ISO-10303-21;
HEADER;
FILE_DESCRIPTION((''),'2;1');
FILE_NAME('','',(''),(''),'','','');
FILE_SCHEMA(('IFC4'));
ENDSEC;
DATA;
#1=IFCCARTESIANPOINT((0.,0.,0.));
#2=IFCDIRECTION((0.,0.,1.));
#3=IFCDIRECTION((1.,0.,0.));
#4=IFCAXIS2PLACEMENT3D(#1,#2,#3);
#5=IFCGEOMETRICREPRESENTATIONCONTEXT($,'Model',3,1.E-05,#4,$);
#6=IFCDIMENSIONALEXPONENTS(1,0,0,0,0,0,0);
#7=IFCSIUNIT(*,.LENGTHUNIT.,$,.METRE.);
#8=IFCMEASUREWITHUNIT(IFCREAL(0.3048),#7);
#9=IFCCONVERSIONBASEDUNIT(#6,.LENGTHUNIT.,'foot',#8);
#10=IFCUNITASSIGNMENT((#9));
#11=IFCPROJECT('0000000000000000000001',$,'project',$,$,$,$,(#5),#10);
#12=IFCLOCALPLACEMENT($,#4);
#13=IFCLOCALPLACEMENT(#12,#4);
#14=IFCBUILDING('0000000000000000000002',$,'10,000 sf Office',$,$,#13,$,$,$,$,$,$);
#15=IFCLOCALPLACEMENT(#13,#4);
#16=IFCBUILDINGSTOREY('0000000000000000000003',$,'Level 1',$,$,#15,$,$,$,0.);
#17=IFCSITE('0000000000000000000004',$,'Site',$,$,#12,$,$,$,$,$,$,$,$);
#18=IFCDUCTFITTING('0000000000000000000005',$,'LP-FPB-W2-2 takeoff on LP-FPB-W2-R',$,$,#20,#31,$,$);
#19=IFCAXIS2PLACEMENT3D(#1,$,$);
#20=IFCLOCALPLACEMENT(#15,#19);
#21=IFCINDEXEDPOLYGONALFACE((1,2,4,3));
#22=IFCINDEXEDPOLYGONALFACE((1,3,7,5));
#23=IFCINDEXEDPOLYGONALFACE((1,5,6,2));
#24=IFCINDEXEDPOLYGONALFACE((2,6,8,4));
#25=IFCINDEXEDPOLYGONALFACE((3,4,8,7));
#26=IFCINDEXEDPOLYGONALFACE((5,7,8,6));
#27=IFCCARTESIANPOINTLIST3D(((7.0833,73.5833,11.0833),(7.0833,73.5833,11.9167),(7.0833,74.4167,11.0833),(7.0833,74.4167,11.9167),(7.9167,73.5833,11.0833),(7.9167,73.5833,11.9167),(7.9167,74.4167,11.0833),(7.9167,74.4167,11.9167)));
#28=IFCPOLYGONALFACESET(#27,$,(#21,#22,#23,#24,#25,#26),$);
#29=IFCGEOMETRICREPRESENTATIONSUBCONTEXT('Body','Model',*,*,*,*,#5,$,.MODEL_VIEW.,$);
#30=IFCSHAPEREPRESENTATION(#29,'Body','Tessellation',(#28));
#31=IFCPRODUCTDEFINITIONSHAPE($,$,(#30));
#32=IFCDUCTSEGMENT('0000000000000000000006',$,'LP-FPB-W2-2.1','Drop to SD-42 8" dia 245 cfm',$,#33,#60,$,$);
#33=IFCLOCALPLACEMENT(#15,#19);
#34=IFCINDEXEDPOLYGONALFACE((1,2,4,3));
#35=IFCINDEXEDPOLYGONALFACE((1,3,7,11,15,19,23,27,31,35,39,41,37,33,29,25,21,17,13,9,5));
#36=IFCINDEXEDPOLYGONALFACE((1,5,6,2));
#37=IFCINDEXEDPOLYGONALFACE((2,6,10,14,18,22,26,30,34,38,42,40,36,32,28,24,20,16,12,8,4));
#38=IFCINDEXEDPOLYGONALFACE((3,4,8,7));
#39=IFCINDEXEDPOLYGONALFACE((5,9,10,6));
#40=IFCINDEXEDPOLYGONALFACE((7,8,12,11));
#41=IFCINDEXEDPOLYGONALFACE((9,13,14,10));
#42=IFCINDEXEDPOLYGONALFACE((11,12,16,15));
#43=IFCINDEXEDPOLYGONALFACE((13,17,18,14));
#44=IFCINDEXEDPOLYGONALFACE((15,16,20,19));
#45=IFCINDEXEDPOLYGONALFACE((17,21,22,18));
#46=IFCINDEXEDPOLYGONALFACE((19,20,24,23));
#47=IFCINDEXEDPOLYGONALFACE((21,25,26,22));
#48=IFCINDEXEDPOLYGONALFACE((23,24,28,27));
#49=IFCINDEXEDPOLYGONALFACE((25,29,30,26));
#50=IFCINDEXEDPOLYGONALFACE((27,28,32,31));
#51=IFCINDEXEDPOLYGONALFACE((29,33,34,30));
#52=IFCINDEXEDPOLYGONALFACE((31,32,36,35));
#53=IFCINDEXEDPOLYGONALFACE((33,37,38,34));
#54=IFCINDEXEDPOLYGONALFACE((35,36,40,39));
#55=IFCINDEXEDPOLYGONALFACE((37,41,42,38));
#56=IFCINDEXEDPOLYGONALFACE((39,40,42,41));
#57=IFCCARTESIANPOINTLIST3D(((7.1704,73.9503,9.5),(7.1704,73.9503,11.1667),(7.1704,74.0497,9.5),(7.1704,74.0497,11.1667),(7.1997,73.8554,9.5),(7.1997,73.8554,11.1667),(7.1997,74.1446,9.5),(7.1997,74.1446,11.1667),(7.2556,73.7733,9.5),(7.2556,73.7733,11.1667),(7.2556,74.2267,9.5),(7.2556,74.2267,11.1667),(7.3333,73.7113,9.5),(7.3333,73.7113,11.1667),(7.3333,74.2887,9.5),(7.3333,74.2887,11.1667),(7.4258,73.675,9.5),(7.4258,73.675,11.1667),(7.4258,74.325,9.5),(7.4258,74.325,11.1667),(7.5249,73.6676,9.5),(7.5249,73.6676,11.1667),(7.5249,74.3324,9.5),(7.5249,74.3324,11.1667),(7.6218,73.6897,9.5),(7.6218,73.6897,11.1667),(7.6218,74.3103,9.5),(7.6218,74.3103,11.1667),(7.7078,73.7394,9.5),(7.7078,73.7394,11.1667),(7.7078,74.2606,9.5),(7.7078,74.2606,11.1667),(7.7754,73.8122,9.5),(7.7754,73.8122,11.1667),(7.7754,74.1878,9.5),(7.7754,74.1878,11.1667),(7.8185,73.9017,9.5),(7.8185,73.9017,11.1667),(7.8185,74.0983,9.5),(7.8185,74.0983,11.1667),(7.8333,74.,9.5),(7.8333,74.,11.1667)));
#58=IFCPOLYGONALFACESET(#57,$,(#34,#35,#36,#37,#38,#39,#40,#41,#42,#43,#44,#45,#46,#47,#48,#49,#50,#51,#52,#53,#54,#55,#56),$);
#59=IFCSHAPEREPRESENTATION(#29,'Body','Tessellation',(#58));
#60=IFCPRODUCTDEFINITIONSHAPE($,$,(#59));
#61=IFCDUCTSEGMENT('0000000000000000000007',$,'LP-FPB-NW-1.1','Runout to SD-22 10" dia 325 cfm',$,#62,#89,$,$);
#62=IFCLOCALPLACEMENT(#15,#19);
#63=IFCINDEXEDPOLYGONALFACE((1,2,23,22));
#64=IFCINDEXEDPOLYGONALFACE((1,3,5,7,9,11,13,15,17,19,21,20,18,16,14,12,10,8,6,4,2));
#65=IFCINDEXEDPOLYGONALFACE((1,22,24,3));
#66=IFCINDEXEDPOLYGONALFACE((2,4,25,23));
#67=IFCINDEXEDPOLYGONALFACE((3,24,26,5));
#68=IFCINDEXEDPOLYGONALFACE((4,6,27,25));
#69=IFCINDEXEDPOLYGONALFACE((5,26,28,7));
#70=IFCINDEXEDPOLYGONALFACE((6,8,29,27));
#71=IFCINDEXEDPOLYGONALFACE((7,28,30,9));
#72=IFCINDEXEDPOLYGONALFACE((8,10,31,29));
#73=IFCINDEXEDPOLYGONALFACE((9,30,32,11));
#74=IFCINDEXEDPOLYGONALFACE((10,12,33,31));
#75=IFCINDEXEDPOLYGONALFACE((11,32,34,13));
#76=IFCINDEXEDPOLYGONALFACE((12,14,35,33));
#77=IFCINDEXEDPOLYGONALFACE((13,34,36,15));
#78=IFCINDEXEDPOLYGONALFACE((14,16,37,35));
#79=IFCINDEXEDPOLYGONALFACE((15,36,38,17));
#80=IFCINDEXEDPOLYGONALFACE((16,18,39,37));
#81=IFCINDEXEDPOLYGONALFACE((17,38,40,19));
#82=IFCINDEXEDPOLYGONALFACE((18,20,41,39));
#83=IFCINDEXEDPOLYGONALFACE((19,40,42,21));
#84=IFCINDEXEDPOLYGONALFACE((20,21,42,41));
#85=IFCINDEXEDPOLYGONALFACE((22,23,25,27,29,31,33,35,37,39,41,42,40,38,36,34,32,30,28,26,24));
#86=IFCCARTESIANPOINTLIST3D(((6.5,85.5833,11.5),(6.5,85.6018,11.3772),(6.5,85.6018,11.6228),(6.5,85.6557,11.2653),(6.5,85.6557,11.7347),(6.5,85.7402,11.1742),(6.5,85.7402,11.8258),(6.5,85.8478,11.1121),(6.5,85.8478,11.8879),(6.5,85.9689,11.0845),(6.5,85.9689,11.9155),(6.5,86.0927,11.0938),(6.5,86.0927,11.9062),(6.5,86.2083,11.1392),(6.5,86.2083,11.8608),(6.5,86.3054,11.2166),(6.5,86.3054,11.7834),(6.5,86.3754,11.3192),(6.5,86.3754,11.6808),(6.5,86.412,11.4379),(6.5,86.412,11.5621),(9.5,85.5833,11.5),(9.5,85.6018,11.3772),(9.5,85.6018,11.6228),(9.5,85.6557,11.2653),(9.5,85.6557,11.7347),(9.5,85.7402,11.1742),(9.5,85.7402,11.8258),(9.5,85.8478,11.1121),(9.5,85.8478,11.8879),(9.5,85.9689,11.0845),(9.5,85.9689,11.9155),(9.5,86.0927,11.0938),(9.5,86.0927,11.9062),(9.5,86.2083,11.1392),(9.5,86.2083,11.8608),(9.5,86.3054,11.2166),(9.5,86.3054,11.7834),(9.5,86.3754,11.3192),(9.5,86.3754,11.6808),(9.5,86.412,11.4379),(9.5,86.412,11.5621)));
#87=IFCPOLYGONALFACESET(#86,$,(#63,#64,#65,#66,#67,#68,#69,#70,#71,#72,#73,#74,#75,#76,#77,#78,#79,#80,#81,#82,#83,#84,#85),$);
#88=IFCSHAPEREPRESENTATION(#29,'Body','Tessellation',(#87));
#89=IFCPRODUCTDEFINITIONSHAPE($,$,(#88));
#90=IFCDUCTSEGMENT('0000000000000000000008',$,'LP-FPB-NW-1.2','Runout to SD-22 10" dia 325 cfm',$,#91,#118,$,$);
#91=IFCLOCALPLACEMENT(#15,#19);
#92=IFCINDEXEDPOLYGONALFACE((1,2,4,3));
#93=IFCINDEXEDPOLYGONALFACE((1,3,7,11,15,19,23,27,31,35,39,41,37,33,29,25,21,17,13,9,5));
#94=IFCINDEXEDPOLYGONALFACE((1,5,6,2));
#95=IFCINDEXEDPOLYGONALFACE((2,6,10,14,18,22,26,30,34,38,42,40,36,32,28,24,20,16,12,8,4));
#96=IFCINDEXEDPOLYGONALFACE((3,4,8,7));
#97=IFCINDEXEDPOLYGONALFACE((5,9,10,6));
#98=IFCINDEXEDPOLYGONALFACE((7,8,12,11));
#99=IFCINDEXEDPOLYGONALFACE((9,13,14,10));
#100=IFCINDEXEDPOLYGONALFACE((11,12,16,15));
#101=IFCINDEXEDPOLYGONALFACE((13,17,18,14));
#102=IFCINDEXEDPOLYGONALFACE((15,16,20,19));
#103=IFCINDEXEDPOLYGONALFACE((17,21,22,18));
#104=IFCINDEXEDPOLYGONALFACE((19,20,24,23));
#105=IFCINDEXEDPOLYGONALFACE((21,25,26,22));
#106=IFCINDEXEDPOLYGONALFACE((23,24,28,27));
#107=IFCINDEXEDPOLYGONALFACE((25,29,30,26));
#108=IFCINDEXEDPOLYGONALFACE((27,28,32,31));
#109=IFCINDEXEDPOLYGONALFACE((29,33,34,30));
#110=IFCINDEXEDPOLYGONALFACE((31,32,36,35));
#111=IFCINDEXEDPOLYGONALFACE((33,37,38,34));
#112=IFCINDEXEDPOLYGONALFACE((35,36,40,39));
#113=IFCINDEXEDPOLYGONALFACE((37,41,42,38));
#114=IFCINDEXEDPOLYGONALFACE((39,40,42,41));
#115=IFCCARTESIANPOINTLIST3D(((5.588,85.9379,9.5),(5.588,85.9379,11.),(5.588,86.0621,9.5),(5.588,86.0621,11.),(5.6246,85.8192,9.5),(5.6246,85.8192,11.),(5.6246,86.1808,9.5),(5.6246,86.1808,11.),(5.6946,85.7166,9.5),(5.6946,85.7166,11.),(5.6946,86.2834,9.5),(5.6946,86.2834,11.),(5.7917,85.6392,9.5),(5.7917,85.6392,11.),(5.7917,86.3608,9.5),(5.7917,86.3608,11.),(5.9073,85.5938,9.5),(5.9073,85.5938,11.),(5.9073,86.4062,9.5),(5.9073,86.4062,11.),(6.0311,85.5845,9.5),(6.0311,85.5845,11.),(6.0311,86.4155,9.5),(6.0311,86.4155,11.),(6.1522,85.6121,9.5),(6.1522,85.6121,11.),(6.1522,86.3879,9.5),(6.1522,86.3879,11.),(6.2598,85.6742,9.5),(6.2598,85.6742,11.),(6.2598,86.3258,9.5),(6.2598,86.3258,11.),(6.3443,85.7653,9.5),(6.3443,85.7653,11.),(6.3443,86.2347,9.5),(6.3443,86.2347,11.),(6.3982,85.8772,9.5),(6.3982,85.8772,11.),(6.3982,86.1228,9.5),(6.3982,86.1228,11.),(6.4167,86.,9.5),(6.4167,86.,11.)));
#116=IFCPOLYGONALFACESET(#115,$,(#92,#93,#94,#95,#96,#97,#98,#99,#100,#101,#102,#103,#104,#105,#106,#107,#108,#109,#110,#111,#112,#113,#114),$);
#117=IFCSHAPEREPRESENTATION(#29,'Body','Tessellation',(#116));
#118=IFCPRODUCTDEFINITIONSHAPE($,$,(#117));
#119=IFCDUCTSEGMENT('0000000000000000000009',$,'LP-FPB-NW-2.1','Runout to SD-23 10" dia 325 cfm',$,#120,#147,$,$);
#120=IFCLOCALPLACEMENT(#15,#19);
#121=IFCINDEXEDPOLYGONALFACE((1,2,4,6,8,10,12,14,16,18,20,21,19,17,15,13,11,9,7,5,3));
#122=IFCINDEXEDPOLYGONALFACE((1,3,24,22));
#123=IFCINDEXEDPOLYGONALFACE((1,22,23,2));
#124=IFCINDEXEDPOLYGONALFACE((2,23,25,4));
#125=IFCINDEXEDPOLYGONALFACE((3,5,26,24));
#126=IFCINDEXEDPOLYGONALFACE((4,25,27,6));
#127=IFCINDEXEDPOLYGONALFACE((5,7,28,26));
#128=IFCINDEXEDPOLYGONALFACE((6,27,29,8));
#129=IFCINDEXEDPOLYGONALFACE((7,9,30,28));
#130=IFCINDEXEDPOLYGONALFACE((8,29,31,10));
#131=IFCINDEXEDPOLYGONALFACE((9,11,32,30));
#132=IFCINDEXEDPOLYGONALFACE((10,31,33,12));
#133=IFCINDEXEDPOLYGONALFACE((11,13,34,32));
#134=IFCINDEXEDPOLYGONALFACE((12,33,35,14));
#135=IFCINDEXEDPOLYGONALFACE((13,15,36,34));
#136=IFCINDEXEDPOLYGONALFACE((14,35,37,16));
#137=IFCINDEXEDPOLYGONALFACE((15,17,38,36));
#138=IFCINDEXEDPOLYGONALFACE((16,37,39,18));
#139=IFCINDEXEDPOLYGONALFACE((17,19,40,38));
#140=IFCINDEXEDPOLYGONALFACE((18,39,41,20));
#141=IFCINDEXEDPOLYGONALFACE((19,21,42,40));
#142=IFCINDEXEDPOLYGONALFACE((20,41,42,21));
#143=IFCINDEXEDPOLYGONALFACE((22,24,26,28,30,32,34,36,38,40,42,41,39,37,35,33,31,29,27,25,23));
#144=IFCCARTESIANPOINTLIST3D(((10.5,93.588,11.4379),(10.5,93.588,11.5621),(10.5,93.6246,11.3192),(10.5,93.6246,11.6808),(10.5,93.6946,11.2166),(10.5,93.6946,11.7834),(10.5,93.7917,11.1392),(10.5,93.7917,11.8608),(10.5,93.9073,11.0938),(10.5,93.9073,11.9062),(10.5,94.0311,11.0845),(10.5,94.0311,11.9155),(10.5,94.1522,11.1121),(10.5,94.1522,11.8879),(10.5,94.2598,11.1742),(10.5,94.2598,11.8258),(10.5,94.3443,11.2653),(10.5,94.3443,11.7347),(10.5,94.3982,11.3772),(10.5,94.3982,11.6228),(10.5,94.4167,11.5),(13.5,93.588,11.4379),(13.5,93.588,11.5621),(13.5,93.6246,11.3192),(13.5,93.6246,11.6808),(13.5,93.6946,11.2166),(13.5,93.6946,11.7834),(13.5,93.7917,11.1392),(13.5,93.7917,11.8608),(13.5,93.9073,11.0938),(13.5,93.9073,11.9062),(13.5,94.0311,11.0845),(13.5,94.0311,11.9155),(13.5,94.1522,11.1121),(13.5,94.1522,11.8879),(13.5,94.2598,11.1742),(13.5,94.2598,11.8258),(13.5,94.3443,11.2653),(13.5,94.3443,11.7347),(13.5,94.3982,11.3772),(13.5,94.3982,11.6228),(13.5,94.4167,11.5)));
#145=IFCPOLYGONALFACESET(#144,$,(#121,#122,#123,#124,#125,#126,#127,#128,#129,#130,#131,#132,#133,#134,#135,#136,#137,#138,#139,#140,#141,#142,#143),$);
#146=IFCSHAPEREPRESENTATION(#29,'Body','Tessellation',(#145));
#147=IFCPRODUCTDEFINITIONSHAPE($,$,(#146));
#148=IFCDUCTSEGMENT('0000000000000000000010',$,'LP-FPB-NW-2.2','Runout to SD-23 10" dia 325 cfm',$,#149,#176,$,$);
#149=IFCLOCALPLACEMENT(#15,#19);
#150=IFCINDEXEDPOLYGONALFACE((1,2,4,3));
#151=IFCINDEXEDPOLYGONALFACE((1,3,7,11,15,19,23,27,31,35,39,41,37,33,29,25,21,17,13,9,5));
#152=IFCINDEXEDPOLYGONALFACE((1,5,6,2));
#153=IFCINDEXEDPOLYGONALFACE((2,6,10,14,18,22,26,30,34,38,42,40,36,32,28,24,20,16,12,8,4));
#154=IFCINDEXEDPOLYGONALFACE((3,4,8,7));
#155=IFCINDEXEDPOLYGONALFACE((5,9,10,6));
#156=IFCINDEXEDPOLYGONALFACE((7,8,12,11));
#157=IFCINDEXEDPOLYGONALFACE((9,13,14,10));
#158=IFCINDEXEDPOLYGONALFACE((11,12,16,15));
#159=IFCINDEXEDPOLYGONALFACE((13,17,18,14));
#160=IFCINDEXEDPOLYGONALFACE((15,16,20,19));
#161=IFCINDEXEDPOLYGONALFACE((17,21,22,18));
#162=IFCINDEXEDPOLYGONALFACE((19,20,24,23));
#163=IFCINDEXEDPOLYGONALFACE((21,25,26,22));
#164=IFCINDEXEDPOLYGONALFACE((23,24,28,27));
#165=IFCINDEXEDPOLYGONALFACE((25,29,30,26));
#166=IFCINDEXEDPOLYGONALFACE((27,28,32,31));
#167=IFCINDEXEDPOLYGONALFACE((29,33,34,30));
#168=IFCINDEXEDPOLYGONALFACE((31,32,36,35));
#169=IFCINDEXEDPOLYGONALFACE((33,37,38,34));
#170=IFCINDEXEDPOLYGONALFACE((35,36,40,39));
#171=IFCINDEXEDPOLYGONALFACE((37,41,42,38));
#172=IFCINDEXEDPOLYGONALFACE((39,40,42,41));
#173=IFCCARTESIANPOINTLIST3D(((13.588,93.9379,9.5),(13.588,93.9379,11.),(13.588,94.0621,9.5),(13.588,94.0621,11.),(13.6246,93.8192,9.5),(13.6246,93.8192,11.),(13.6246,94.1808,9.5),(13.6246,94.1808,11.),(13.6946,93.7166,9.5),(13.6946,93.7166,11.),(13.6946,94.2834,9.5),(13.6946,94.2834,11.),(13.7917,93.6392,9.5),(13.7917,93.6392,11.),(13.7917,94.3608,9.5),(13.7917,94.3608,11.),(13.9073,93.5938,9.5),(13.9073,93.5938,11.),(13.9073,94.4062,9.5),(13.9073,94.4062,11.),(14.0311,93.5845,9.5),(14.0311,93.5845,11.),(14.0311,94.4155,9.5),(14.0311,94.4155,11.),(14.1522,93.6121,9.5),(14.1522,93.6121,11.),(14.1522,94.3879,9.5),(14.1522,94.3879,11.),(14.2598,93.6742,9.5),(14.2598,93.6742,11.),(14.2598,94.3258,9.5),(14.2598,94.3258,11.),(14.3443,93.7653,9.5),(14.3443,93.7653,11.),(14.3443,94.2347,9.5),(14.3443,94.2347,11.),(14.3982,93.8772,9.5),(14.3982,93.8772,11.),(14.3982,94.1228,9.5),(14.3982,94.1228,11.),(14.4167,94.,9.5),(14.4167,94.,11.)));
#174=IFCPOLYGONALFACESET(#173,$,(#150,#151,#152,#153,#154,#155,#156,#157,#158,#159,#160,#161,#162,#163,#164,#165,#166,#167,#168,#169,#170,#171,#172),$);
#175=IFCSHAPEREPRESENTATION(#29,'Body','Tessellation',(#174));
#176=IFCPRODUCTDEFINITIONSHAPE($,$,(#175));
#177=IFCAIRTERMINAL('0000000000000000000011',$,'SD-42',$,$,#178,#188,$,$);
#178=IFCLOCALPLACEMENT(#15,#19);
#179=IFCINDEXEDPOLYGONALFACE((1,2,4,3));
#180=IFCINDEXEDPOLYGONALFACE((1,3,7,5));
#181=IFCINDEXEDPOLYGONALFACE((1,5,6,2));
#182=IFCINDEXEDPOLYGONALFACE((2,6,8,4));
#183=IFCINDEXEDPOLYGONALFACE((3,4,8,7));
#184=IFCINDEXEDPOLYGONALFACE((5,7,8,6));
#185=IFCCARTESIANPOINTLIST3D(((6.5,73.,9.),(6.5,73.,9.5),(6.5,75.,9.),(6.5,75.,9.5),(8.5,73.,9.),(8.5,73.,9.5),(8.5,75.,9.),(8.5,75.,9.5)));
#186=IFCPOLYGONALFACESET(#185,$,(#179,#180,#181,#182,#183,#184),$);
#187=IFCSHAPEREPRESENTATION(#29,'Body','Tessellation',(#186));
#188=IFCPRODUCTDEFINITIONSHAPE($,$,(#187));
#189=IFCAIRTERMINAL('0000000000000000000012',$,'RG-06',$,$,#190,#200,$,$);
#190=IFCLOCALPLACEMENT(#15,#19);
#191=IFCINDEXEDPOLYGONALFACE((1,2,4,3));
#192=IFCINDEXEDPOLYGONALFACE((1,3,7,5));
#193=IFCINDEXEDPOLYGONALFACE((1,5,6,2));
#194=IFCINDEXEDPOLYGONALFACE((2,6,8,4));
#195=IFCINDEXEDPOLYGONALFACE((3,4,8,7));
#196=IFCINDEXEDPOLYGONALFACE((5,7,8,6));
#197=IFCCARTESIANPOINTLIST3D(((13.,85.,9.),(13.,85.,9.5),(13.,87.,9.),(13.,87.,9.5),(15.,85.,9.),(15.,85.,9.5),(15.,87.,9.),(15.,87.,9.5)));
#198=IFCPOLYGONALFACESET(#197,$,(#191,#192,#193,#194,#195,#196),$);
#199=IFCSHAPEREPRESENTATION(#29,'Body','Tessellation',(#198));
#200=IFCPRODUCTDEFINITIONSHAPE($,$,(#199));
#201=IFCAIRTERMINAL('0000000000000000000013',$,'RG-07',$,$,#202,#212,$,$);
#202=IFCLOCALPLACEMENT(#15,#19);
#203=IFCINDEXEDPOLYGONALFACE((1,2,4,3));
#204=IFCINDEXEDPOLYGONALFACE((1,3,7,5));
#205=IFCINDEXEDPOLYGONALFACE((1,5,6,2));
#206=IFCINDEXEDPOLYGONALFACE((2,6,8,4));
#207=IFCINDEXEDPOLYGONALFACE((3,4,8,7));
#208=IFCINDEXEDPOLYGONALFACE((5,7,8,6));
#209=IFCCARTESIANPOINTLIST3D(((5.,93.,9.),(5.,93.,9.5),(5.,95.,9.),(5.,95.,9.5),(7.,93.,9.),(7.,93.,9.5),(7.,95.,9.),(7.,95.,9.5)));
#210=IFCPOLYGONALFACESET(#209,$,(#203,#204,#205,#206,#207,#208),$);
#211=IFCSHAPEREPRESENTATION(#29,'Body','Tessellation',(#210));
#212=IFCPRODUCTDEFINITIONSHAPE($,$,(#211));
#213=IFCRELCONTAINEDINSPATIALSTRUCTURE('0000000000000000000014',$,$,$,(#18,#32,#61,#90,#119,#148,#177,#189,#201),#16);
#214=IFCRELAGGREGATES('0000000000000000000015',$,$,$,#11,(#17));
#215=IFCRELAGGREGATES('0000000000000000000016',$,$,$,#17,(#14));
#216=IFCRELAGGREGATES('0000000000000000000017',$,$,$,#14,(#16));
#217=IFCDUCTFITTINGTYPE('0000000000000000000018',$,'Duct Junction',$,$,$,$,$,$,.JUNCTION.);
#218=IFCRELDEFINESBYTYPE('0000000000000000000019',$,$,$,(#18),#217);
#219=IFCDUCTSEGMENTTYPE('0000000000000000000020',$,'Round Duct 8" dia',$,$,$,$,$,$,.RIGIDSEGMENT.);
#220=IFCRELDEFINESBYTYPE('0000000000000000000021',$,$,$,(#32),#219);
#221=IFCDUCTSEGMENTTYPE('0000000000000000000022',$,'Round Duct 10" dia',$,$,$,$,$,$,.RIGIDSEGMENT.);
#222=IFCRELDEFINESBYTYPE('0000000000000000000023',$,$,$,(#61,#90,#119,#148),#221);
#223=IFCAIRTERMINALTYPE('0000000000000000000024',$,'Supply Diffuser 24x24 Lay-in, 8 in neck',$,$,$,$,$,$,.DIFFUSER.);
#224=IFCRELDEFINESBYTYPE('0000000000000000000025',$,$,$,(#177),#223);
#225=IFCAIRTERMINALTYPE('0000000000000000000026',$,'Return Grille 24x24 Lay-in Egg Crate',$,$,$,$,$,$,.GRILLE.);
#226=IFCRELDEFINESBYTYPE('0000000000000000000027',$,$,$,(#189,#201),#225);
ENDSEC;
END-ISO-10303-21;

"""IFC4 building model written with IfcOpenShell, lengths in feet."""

from ifc_helpers import new_model, entity, si_unit, converted_unit, frame, origin_with_axes, place, context, subcontext, project, spatial, rectangle, circle, extrude, type_object, element, save


model = new_model("IFC4")

# Units and contexts
model_context = context("Model", 3, precision=1e-05, world=origin_with_axes())
body_context = subcontext(model_context, "Body", "Model", "MODEL_VIEW")
ifc_project = project(units=[converted_unit("LENGTHUNIT", "foot", entity("IfcReal", 0.3048), si_unit("LENGTHUNIT", "METRE"), dimensions=[1, 0, 0, 0, 0, 0, 0])], contexts=[model_context])

# Site, building, storey
site_placement = place(None, origin_with_axes())
site = spatial("IfcSite", under=ifc_project, at=site_placement, Name="Site")
building_placement = place(site_placement, origin_with_axes())
building = spatial("IfcBuilding", under=site, at=building_placement, Name="10,000 sf Office")
storey_placement = place(building_placement, origin_with_axes())
storey = spatial("IfcBuildingStorey", under=building, at=storey_placement, Name="Level 1", Elevation=0.0)

# Duct fitting
duct_fitting_type_1 = type_object("IfcDuctFittingType", Name="Duct Junction", PredefinedType="JUNCTION")
duct_fitting_placement = place(storey_placement, frame((7.5, 74.0, 11.0833), z_axis=(0.0, 0.0, 1.0), x_axis=(1.0, 0.0, 0.0)))
element("IfcDuctFitting", 1, at=duct_fitting_placement, inside=storey, type_object=duct_fitting_type_1, Name="LP-FPB-W2-2 takeoff on LP-FPB-W2-R", context=body_context, shape_type="SweptSolid", body=[
    extrude(rectangle(XDim=0.8333, YDim=0.8333), None, (0.0, 0.0, 1.0), 0.8333),
])

# Duct segments
duct_segment_type_1 = type_object("IfcDuctSegmentType", Name="Round Duct 8\" dia", PredefinedType="RIGIDSEGMENT")
duct_segment_1_placement = place(storey_placement, frame((7.5, 74.0, 11.1667), z_axis=(0.0, 0.0, -1.0), x_axis=(1.0, 0.0, 0.0)))
element("IfcDuctSegment", 2, at=duct_segment_1_placement, inside=storey, type_object=duct_segment_type_1, Name="LP-FPB-W2-2.1", Description="Drop to SD-42 8\" dia 245 cfm", context=body_context, shape_type="SweptSolid", body=[
    extrude(circle(Radius=0.3333), None, (0.0, 0.0, 1.0), 1.6667),
])
duct_segment_type_2 = type_object("IfcDuctSegmentType", Name="Round Duct 10\" dia", PredefinedType="RIGIDSEGMENT")
duct_segment_2_placement = place(storey_placement, frame((9.5, 86.0, 11.5), z_axis=(-1.0, 0.0, 0.0), x_axis=(0.0, -1.0, 0.0)))
element("IfcDuctSegment", 3, at=duct_segment_2_placement, inside=storey, type_object=duct_segment_type_2, Name="LP-FPB-NW-1.1", Description="Runout to SD-22 10\" dia 325 cfm", context=body_context, shape_type="SweptSolid", body=[
    extrude(circle(Radius=0.4167), None, (0.0, 0.0, 1.0), 3.0),
])
duct_segment_3_placement = place(storey_placement, frame((6.0, 86.0, 11.0), z_axis=(0.0, 0.0, -1.0), x_axis=(1.0, 0.0, 0.0)))
element("IfcDuctSegment", 4, at=duct_segment_3_placement, inside=storey, type_object=duct_segment_type_2, Name="LP-FPB-NW-1.2", Description="Runout to SD-22 10\" dia 325 cfm", context=body_context, shape_type="SweptSolid", body=[
    extrude(circle(Radius=0.4167), None, (0.0, 0.0, 1.0), 1.5),
])
duct_segment_4_placement = place(storey_placement, frame((10.5, 94.0, 11.5), z_axis=(1.0, 0.0, 0.0), x_axis=(0.0, 1.0, 0.0)))
element("IfcDuctSegment", 5, at=duct_segment_4_placement, inside=storey, type_object=duct_segment_type_2, Name="LP-FPB-NW-2.1", Description="Runout to SD-23 10\" dia 325 cfm", context=body_context, shape_type="SweptSolid", body=[
    extrude(circle(Radius=0.4167), None, (0.0, 0.0, 1.0), 3.0),
])
duct_segment_5_placement = place(storey_placement, frame((14.0, 94.0, 11.0), z_axis=(0.0, 0.0, -1.0), x_axis=(1.0, 0.0, 0.0)))
element("IfcDuctSegment", 6, at=duct_segment_5_placement, inside=storey, type_object=duct_segment_type_2, Name="LP-FPB-NW-2.2", Description="Runout to SD-23 10\" dia 325 cfm", context=body_context, shape_type="SweptSolid", body=[
    extrude(circle(Radius=0.4167), None, (0.0, 0.0, 1.0), 1.5),
])

# Air terminals
air_terminal_type_1 = type_object("IfcAirTerminalType", Name="Supply Diffuser 24x24 Lay-in, 8 in neck", PredefinedType="DIFFUSER")
air_terminal_placement = place(storey_placement, frame((7.5, 74.0, 9.0), z_axis=(0.0, 0.0, 1.0), x_axis=(1.0, 0.0, 0.0)))
element("IfcAirTerminal", 7, at=air_terminal_placement, inside=storey, type_object=air_terminal_type_1, Name="SD-42", context=body_context, shape_type="SweptSolid", body=[
    extrude(rectangle(XDim=2.0, YDim=2.0), None, (0.0, 0.0, 1.0), 0.5),
])
air_terminal_type_2 = type_object("IfcAirTerminalType", Name="Return Grille 24x24 Lay-in Egg Crate", PredefinedType="GRILLE")
for number, where, z_axis, x_axis, name in (
    (8, (14.0, 86.0, 9.0), (0.0, 0.0, 1.0), (1.0, 0.0, 0.0), "RG-06"),
    (9, (6.0, 94.0, 9.0), (0.0, 0.0, 1.0), (1.0, 0.0, 0.0), "RG-07"),
):
    element("IfcAirTerminal", number, at=place(storey_placement, frame(where, z_axis=z_axis, x_axis=x_axis)), inside=storey, type_object=air_terminal_type_2, Name=name, context=body_context, shape_type="SweptSolid", body=[
        extrude(rectangle(XDim=2.0, YDim=2.0), None, (0.0, 0.0, 1.0), 0.5),
    ])

save(model, "model.ifc")
